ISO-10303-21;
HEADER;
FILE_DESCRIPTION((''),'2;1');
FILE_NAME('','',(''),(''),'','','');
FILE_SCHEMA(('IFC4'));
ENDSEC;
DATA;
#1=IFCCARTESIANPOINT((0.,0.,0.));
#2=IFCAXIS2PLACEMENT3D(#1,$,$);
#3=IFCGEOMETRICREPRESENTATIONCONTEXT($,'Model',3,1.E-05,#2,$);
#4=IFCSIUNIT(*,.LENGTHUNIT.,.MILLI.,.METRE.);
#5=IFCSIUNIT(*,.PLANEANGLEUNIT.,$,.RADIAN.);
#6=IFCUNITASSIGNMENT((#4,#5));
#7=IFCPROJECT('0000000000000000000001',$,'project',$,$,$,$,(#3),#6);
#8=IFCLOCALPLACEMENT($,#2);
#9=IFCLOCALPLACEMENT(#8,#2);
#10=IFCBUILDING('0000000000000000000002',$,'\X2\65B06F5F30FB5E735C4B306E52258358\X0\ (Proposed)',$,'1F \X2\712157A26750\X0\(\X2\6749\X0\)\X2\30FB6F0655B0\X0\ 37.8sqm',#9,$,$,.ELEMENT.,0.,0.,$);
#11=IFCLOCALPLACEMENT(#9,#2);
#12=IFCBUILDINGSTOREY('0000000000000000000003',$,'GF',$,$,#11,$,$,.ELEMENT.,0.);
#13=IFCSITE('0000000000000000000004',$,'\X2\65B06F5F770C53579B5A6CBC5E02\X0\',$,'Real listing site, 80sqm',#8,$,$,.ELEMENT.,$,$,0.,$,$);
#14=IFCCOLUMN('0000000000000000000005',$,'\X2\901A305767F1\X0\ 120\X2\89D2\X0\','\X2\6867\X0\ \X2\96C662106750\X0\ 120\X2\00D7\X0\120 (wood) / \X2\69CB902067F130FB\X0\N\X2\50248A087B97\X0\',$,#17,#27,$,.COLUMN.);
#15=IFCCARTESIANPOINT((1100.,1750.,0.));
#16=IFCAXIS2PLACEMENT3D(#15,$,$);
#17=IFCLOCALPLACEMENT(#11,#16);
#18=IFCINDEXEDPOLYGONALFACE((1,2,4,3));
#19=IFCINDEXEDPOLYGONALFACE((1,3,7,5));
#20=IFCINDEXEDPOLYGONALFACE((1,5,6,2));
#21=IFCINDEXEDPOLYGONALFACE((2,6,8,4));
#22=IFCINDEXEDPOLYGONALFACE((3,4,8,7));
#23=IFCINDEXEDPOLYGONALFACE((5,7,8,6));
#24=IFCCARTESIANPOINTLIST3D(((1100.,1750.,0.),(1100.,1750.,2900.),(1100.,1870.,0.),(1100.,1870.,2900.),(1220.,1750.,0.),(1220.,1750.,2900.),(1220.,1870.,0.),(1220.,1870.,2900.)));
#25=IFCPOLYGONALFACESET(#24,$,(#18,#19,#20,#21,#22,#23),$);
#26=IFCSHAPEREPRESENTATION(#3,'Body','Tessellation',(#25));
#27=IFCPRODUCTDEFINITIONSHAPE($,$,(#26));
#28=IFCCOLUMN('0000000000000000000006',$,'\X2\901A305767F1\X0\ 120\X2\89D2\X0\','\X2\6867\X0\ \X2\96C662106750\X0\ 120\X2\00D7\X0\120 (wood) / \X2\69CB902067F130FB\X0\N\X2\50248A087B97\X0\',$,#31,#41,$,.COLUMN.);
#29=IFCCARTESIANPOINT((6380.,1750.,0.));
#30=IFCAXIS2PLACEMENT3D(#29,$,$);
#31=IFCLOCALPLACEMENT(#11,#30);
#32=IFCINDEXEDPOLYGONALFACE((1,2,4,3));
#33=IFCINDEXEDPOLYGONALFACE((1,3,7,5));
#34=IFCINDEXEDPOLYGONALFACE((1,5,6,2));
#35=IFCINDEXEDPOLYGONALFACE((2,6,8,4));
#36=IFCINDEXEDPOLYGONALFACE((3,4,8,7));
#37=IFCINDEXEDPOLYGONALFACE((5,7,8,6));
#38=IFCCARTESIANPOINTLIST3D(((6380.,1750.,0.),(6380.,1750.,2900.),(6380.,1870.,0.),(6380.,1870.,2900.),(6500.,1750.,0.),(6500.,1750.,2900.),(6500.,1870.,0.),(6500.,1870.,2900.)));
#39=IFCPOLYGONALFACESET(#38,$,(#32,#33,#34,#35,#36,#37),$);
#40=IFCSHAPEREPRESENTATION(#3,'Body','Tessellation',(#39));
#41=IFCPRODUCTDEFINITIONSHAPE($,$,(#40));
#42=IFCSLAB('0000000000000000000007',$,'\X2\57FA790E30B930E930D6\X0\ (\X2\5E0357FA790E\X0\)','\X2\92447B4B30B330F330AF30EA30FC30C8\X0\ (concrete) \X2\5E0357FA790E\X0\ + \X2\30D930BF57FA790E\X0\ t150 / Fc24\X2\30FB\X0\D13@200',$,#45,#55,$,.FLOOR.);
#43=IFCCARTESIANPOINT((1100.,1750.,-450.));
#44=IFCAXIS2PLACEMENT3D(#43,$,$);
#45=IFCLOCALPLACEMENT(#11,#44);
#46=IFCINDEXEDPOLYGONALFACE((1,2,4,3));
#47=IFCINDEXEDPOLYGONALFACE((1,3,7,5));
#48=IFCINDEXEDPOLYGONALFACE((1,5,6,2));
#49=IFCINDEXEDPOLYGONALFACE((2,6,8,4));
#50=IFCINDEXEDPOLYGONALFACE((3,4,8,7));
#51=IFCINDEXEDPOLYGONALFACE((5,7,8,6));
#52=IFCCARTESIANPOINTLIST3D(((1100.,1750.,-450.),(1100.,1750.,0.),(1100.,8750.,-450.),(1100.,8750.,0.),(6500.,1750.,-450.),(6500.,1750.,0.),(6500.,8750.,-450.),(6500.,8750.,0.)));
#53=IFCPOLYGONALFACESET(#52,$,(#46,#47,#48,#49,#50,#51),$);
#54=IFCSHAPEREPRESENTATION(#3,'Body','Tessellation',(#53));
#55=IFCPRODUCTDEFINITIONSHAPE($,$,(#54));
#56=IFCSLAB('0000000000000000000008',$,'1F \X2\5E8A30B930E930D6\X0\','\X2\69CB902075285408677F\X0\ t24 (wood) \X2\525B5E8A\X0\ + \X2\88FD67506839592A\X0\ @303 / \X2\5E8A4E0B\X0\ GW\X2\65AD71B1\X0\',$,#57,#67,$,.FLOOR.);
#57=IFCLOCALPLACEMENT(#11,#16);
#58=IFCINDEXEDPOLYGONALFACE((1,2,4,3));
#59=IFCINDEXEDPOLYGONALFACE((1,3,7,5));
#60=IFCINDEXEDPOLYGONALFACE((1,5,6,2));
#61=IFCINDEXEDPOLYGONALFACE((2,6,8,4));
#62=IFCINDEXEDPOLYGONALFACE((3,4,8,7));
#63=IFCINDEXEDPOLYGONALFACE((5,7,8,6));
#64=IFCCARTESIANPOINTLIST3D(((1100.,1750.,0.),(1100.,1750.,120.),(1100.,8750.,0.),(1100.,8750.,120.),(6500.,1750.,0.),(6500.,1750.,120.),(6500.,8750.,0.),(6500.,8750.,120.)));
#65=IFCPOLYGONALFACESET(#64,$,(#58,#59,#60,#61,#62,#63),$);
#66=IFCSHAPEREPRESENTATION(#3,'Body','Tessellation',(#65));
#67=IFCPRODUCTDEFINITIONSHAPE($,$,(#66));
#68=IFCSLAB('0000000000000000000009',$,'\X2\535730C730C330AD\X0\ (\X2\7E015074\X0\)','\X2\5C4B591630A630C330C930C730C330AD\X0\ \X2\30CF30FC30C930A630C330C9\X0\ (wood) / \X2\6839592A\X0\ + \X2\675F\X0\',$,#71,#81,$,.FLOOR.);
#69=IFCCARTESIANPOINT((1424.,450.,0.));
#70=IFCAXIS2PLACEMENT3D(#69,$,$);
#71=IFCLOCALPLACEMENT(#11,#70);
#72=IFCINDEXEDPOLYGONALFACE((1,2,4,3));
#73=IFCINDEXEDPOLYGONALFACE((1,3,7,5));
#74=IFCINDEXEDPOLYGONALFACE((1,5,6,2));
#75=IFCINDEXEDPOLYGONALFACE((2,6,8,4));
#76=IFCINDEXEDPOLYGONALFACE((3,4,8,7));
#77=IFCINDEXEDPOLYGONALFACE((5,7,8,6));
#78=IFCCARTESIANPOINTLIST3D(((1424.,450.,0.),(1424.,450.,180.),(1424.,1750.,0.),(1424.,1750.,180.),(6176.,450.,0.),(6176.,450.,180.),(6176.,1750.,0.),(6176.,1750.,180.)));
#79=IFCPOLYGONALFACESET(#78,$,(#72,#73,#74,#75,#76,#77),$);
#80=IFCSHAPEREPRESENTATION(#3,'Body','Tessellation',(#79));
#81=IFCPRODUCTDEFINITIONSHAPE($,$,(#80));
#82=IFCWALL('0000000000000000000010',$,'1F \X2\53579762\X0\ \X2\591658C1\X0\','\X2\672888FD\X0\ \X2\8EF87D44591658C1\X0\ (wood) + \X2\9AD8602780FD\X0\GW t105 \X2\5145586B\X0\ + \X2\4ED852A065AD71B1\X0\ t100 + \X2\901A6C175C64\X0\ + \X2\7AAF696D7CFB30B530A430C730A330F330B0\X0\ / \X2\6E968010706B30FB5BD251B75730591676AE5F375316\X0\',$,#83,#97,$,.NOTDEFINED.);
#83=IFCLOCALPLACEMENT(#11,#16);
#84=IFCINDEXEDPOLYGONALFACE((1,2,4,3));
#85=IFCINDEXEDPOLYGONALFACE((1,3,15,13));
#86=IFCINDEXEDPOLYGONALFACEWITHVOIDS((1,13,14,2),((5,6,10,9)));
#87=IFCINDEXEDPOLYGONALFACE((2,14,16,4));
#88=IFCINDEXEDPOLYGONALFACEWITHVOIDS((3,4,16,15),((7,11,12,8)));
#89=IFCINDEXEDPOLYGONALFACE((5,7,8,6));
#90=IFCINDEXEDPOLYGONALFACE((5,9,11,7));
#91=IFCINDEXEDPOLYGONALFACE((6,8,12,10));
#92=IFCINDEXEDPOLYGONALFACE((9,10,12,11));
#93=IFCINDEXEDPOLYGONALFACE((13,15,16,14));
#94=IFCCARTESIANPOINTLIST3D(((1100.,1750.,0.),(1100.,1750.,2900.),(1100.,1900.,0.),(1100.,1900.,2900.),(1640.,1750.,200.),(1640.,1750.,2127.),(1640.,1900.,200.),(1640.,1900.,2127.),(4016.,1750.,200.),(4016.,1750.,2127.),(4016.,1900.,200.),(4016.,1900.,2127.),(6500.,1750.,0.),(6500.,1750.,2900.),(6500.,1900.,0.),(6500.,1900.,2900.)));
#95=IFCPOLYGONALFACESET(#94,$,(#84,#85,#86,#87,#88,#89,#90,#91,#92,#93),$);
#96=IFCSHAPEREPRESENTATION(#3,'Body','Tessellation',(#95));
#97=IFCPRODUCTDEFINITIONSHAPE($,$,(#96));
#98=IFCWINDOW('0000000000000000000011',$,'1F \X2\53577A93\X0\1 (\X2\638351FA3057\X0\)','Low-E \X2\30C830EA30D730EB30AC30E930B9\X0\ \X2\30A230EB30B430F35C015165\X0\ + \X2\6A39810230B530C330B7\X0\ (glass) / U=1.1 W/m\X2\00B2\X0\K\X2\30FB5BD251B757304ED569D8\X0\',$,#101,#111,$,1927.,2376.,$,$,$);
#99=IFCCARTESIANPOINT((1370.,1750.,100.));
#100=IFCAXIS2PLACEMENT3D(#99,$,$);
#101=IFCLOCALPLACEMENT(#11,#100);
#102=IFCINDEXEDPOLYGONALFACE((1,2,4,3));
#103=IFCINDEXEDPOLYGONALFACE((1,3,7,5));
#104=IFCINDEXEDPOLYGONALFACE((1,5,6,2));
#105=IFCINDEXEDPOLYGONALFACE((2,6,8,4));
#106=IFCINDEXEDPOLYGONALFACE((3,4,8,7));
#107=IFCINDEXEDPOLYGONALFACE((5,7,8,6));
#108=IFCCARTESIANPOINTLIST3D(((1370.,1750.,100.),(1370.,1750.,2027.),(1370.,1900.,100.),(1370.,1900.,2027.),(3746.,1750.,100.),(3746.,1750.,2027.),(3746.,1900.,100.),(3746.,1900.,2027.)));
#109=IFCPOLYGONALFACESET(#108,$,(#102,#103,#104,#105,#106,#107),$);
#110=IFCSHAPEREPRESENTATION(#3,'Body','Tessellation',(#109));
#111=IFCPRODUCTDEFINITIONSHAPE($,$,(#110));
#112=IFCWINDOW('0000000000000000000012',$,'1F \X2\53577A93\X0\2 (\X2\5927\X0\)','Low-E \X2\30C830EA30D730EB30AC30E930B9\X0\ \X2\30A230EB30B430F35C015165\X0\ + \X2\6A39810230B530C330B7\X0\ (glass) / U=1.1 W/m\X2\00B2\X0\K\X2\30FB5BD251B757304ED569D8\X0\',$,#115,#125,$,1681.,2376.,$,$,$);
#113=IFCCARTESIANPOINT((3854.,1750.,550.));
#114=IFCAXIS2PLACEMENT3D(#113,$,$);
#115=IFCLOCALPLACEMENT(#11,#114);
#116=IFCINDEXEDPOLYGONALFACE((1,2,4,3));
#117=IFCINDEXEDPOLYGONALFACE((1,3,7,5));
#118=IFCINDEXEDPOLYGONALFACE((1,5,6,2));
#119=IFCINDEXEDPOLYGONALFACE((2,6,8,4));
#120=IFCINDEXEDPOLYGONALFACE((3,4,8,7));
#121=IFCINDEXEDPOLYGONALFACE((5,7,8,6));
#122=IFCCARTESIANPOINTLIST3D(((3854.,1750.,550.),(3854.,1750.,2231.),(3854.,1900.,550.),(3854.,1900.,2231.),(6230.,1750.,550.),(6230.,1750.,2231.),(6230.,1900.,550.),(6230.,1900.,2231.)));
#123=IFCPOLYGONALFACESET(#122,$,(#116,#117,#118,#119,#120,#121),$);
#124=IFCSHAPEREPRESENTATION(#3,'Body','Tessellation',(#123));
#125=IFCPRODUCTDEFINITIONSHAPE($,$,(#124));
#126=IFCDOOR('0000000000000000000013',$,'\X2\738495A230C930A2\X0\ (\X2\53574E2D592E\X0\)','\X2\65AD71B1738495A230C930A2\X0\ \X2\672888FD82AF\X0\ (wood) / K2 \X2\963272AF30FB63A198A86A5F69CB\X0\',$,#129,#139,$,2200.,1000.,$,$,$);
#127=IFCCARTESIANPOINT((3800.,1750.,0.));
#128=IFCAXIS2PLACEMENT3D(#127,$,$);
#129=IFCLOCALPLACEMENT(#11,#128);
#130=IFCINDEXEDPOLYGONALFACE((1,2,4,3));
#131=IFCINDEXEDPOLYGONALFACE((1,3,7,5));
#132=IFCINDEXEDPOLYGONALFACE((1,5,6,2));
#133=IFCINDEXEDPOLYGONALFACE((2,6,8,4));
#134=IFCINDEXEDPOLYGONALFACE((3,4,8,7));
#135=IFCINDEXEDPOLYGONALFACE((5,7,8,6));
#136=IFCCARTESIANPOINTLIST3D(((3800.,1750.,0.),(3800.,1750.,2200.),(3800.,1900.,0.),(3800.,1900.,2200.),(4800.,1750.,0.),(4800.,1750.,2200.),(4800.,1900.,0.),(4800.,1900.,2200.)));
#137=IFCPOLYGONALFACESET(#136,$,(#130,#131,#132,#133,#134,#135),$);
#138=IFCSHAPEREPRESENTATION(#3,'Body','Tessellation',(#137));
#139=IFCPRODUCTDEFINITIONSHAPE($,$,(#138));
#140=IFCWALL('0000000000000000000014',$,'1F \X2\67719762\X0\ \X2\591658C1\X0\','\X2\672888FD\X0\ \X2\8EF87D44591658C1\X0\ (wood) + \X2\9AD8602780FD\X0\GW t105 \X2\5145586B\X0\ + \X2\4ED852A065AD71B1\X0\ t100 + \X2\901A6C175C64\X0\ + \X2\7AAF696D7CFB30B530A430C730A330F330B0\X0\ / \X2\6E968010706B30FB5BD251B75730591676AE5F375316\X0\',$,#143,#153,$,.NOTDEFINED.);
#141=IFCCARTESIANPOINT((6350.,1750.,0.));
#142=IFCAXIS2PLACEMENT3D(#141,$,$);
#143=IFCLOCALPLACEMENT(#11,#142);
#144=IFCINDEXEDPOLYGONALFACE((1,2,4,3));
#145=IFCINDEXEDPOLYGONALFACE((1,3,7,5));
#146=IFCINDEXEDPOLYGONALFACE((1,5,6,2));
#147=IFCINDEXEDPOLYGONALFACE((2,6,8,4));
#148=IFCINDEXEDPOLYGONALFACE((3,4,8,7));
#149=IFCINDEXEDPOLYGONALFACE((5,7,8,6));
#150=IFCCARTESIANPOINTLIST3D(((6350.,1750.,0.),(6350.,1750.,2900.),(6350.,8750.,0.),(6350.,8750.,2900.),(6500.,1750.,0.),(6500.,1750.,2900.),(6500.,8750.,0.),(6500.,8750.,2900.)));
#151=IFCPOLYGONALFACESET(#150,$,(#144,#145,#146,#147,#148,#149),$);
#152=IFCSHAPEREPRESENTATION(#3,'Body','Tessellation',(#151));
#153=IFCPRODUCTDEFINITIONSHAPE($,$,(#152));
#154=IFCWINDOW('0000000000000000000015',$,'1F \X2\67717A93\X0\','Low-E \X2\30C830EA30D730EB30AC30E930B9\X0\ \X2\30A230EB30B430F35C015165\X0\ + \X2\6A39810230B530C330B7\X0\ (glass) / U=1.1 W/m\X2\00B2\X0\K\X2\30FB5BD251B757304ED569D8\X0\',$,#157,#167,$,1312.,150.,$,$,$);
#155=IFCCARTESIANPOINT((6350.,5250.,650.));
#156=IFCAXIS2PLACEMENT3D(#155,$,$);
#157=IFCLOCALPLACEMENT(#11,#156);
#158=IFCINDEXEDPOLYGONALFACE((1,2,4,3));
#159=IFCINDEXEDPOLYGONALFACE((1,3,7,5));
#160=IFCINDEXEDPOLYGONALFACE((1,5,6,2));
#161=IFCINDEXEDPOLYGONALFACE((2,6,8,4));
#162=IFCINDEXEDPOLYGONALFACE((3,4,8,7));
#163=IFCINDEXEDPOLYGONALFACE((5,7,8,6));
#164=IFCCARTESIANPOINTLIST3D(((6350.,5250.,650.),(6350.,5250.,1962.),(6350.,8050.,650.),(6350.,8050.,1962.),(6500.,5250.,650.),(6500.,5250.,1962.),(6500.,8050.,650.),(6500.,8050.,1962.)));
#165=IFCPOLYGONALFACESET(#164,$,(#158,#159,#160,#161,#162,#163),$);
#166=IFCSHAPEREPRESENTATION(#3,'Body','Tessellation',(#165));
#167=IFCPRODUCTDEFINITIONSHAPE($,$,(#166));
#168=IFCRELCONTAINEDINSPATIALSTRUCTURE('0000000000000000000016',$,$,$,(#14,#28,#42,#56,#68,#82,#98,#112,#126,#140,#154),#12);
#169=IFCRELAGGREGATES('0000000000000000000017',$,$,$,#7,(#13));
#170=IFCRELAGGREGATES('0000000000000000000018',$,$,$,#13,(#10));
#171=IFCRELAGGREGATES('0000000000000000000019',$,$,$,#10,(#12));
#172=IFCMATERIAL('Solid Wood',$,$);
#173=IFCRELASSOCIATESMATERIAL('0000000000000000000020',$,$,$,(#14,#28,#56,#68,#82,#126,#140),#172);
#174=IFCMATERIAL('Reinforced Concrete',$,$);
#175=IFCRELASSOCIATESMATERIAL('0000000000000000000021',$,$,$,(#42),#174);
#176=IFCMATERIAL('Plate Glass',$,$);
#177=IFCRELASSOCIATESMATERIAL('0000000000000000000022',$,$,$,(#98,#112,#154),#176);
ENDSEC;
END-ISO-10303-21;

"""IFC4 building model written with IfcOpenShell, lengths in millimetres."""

from ifc_helpers import new_model, si_unit, frame, frame_2d, origin, place, context, project, spatial, rectangle, extrude, material, element, fill, save


model = new_model("IFC4")

# Units and contexts
model_context = context("Model", 3, precision=1e-05, world=origin())
ifc_project = project(units=[si_unit("LENGTHUNIT", "METRE", prefix="MILLI"), si_unit("PLANEANGLEUNIT", "RADIAN")], contexts=[model_context])

# Site, building, storey
site_placement = place(None, origin())
site = spatial("IfcSite", under=ifc_project, at=site_placement, Name="新潟県南魚沼市", ObjectType="Real listing site, 80sqm", CompositionType="ELEMENT", RefElevation=0.0)
building_placement = place(site_placement, origin())
building = spatial("IfcBuilding", under=site, at=building_placement, Name="新潟・平屋の別荘 (Proposed)", ObjectType="1F 無垢材(杉)・漆喰 37.8sqm", CompositionType="ELEMENT", ElevationOfRefHeight=0.0, ElevationOfTerrain=0.0)
storey_placement = place(building_placement, origin())
storey = spatial("IfcBuildingStorey", under=building, at=storey_placement, Name="GF", CompositionType="ELEMENT", Elevation=0.0)

# Columns
ifc_material_1 = material(Name="Solid Wood")
column_1_placement = place(storey_placement, frame((1100.0, 1750.0, 0.0)))
element("IfcColumn", 1, at=column_1_placement, inside=storey, material=ifc_material_1, Name="通し柱 120角", Description="桧 集成材 120×120 (wood) / 構造柱・N値計算", PredefinedType="COLUMN", context=model_context, shape_type="SweptSolid", body=[
    extrude(rectangle(XDim=120.0, YDim=120.0, at=frame_2d((60.0, 60.0))), frame((1100.0, 1750.0, 0.0)), (0.0, 0.0, 1.0), 2900.0),
])
column_2_placement = place(storey_placement, frame((6380.0, 1750.0, 0.0)))
element("IfcColumn", 2, at=column_2_placement, inside=storey, material=ifc_material_1, Name="通し柱 120角", Description="桧 集成材 120×120 (wood) / 構造柱・N値計算", PredefinedType="COLUMN", context=model_context, shape_type="SweptSolid", body=[
    extrude(rectangle(XDim=120.0, YDim=120.0, at=frame_2d((60.0, 60.0))), frame((6380.0, 1750.0, 0.0)), (0.0, 0.0, 1.0), 2900.0),
])

# Slabs
ifc_material_2 = material(Name="Reinforced Concrete")
slab_1_placement = place(storey_placement, frame((1100.0, 1750.0, -450.0)))
element("IfcSlab", 3, at=slab_1_placement, inside=storey, material=ifc_material_2, Name="基礎スラブ (布基礎)", Description="鉄筋コンクリート (concrete) 布基礎 + ベタ基礎 t150 / Fc24・D13@200", PredefinedType="FLOOR", context=model_context, shape_type="SweptSolid", body=[
    extrude(rectangle(XDim=5400.0, YDim=7000.0, at=frame_2d((2700.0, 3500.0))), frame((1100.0, 1750.0, -450.0)), (0.0, 0.0, 1.0), 450.0),
])
slab_2_placement = place(storey_placement, frame((1100.0, 1750.0, 0.0)))
element("IfcSlab", 4, at=slab_2_placement, inside=storey, material=ifc_material_1, Name="1F 床スラブ", Description="構造用合板 t24 (wood) 剛床 + 製材根太 @303 / 床下 GW断熱", PredefinedType="FLOOR", context=model_context, shape_type="SweptSolid", body=[
    extrude(rectangle(XDim=5400.0, YDim=7000.0, at=frame_2d((2700.0, 3500.0))), frame((1100.0, 1750.0, 0.0)), (0.0, 0.0, 1.0), 120.0),
])
slab_3_placement = place(storey_placement, frame((1424.0, 450.0, 0.0)))
element("IfcSlab", 5, at=slab_3_placement, inside=storey, material=ifc_material_1, Name="南デッキ (縁側)", Description="屋外ウッドデッキ ハードウッド (wood) / 根太 + 束", PredefinedType="FLOOR", context=model_context, shape_type="SweptSolid", body=[
    extrude(rectangle(XDim=4752.0, YDim=1300.0, at=frame_2d((2376.0, 650.0))), frame((1424.0, 450.0, 0.0)), (0.0, 0.0, 1.0), 180.0),
])

# Wall, openings, windows, door
wall_1_placement = place(storey_placement, frame((1100.0, 1750.0, 0.0)))
wall_1 = element("IfcWall", 6, at=wall_1_placement, inside=storey, material=ifc_material_1, Name="1F 南面 外壁", Description="木製 軸組外壁 (wood) + 高性能GW t105 充填 + 付加断熱 t100 + 通気層 + 窯業系サイディング / 準耐火・寒冷地外皮強化", PredefinedType="NOTDEFINED", context=model_context, shape_type="SweptSolid", body=[
    extrude(rectangle(XDim=5400.0, YDim=150.0, at=frame_2d((2700.0, 75.0))), frame((1100.0, 1750.0, 0.0)), (0.0, 0.0, 1.0), 2900.0),
])
opening_1_placement = place(storey_placement, frame((1370.0, 1750.0, 100.0)))
opening_1 = element("IfcOpeningElement", 7, at=opening_1_placement, cuts=wall_1, PredefinedType="NOTDEFINED", context=model_context, shape_type="SweptSolid", body=[
    extrude(rectangle(XDim=2376.0, YDim=150.0, at=frame_2d((1188.0, 75.0))), frame((1370.0, 1750.0, 100.0)), (0.0, 0.0, 1.0), 1927.0),
])
opening_2_placement = place(storey_placement, frame((3854.0, 1750.0, 550.0)))
opening_2 = element("IfcOpeningElement", 8, at=opening_2_placement, cuts=wall_1, PredefinedType="NOTDEFINED", context=model_context, shape_type="SweptSolid", body=[
    extrude(rectangle(XDim=2376.0, YDim=150.0, at=frame_2d((1188.0, 75.0))), frame((3854.0, 1750.0, 550.0)), (0.0, 0.0, 1.0), 1681.0),
])
opening_3_placement = place(storey_placement, frame((3800.0, 1750.0, 0.0)))
opening_3 = element("IfcOpeningElement", 9, at=opening_3_placement, cuts=wall_1, PredefinedType="NOTDEFINED", context=model_context, shape_type="SweptSolid", body=[
    extrude(rectangle(XDim=1000.0, YDim=150.0, at=frame_2d((500.0, 75.0))), frame((3800.0, 1750.0, 0.0)), (0.0, 0.0, 1.0), 2200.0),
])
ifc_material_3 = material(Name="Plate Glass")
window_1_placement = place(storey_placement, frame((1370.0, 1750.0, 100.0)))
window_1 = element("IfcWindow", 10, at=window_1_placement, inside=storey, material=ifc_material_3, Name="1F 南窓1 (掃出し)", Description="Low-E トリプルガラス アルゴン封入 + 樹脂サッシ (glass) / U=1.1 W/m²K・寒冷地仕様", OverallHeight=1927.0, OverallWidth=2376.0, context=model_context, shape_type="SweptSolid", body=[
    extrude(rectangle(XDim=2376.0, YDim=150.0, at=frame_2d((1188.0, 75.0))), frame((1370.0, 1750.0, 100.0)), (0.0, 0.0, 1.0), 1927.0),
])
fill(opening_1, window_1)
window_2_placement = place(storey_placement, frame((3854.0, 1750.0, 550.0)))
window_2 = element("IfcWindow", 11, at=window_2_placement, inside=storey, material=ifc_material_3, Name="1F 南窓2 (大)", Description="Low-E トリプルガラス アルゴン封入 + 樹脂サッシ (glass) / U=1.1 W/m²K・寒冷地仕様", OverallHeight=1681.0, OverallWidth=2376.0, context=model_context, shape_type="SweptSolid", body=[
    extrude(rectangle(XDim=2376.0, YDim=150.0, at=frame_2d((1188.0, 75.0))), frame((3854.0, 1750.0, 550.0)), (0.0, 0.0, 1.0), 1681.0),
])
fill(opening_2, window_2)
door_placement = place(storey_placement, frame((3800.0, 1750.0, 0.0)))
door = element("IfcDoor", 12, at=door_placement, inside=storey, material=ifc_material_1, Name="玄関ドア (南中央)", Description="断熱玄関ドア 木製芯 (wood) / K2 防犯・採風機構", OverallHeight=2200.0, OverallWidth=1000.0, context=model_context, shape_type="SweptSolid", body=[
    extrude(rectangle(XDim=1000.0, YDim=150.0, at=frame_2d((500.0, 75.0))), frame((3800.0, 1750.0, 0.0)), (0.0, 0.0, 1.0), 2200.0),
])
fill(opening_3, door)

# Wall, opening, window
wall_2_placement = place(storey_placement, frame((6350.0, 1750.0, 0.0)))
wall_2 = element("IfcWall", 13, at=wall_2_placement, inside=storey, material=ifc_material_1, Name="1F 東面 外壁", Description="木製 軸組外壁 (wood) + 高性能GW t105 充填 + 付加断熱 t100 + 通気層 + 窯業系サイディング / 準耐火・寒冷地外皮強化", PredefinedType="NOTDEFINED", context=model_context, shape_type="SweptSolid", body=[
    extrude(rectangle(XDim=150.0, YDim=7000.0, at=frame_2d((75.0, 3500.0))), frame((6350.0, 1750.0, 0.0)), (0.0, 0.0, 1.0), 2900.0),
])
opening_4_placement = place(storey_placement, frame((6350.0, 5250.0, 650.0)))
opening_4 = element("IfcOpeningElement", 14, at=opening_4_placement, cuts=wall_2, PredefinedType="NOTDEFINED", context=model_context, shape_type="SweptSolid", body=[
    extrude(rectangle(XDim=150.0, YDim=2800.0, at=frame_2d((75.0, 1400.0))), frame((6350.0, 5250.0, 650.0)), (0.0, 0.0, 1.0), 1312.0),
])
window_3_placement = place(storey_placement, frame((6350.0, 5250.0, 650.0)))
window_3 = element("IfcWindow", 15, at=window_3_placement, inside=storey, material=ifc_material_3, Name="1F 東窓", Description="Low-E トリプルガラス アルゴン封入 + 樹脂サッシ (glass) / U=1.1 W/m²K・寒冷地仕様", OverallHeight=1312.0, OverallWidth=150.0, context=model_context, shape_type="SweptSolid", body=[
    extrude(rectangle(XDim=150.0, YDim=2800.0, at=frame_2d((75.0, 1400.0))), frame((6350.0, 5250.0, 650.0)), (0.0, 0.0, 1.0), 1312.0),
])
fill(opening_4, window_3)

save(model, "model.ifc")
